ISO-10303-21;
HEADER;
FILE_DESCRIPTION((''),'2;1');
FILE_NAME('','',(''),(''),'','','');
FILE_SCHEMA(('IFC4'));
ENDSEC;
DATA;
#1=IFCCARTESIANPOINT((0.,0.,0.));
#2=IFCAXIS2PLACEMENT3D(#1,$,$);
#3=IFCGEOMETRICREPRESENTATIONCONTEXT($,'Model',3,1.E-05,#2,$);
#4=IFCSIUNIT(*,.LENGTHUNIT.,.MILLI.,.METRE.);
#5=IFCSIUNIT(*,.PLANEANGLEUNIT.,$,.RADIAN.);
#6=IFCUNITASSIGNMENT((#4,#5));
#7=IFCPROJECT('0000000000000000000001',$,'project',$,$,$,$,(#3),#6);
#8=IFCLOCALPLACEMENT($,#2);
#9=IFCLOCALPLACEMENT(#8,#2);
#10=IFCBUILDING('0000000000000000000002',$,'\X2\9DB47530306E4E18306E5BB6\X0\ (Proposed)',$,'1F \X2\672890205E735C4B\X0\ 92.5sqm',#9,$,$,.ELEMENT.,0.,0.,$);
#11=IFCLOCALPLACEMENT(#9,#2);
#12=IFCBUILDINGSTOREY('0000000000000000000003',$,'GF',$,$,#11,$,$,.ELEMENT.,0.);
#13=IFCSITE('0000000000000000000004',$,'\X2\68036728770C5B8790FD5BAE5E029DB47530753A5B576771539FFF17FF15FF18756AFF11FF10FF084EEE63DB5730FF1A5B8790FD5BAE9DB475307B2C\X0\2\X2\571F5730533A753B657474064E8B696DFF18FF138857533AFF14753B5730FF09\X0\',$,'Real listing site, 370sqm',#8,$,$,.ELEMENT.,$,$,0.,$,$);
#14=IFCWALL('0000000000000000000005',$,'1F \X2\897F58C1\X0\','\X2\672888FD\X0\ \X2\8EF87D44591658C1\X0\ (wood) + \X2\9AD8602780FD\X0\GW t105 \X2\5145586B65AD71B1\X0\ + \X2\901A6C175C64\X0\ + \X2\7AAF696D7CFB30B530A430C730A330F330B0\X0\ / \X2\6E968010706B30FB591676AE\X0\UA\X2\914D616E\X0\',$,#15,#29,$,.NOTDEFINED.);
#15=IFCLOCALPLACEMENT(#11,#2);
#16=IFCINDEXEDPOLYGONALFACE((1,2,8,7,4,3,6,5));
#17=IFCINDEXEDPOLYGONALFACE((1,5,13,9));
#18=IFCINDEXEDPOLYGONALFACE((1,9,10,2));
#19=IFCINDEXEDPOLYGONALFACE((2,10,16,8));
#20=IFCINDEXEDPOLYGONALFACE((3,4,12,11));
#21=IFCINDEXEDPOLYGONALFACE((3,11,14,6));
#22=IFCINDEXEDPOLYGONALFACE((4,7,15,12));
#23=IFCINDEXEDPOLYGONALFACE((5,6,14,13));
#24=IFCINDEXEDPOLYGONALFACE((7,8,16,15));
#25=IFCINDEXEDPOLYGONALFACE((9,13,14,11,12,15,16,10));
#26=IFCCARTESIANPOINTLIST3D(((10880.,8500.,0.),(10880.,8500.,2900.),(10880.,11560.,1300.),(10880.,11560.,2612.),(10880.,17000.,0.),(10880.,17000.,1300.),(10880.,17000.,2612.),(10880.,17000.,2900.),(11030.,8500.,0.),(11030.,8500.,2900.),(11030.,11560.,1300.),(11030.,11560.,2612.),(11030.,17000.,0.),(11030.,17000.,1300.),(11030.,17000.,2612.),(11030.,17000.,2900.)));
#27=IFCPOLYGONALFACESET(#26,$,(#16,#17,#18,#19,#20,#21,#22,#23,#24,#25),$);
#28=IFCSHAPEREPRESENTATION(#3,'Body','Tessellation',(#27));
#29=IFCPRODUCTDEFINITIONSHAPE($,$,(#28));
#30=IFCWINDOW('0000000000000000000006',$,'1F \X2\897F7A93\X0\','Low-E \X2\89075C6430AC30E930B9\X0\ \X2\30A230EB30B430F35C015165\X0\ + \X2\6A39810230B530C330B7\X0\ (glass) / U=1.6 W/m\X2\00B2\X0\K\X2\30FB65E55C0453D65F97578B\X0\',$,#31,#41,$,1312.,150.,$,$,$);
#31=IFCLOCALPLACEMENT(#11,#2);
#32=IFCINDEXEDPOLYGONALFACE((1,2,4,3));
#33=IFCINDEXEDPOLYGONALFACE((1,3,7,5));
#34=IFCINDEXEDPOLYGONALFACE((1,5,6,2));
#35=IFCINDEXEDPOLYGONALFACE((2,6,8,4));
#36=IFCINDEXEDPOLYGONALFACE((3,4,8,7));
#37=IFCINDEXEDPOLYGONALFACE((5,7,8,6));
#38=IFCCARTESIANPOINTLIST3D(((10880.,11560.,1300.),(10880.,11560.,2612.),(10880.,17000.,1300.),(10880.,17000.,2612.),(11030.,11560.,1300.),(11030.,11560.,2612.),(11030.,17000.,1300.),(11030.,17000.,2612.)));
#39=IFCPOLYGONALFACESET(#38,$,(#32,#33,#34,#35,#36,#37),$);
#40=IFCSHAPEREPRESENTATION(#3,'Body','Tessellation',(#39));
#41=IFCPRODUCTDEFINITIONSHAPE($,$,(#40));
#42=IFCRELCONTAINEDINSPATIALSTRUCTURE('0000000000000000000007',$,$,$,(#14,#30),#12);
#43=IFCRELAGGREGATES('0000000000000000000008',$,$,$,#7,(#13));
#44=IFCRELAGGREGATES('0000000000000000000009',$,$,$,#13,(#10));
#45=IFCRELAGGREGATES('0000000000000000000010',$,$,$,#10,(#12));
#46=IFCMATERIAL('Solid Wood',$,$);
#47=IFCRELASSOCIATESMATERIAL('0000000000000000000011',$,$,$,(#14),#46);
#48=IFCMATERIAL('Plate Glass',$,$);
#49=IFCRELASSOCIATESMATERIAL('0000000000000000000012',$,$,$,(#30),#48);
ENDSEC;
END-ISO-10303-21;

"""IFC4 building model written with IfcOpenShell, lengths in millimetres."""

from ifc_helpers import new_model, si_unit, frame, frame_2d, origin, place, context, project, spatial, rectangle, extrude, material, element, fill, save


model = new_model("IFC4")

# Units and contexts
model_context = context("Model", 3, precision=1e-05, world=origin())
ifc_project = project(units=[si_unit("LENGTHUNIT", "METRE", prefix="MILLI"), si_unit("PLANEANGLEUNIT", "RADIAN")], contexts=[model_context])

# Site, building, storey
site_placement = place(None, origin())
site = spatial("IfcSite", under=ifc_project, at=site_placement, Name="栃木県宇都宮市鶴田町字東原７５８番１０（仮換地：宇都宮鶴田第2土地区画整理事業８３街区４画地）", ObjectType="Real listing site, 370sqm", CompositionType="ELEMENT", RefElevation=0.0)
building_placement = place(site_placement, origin())
building = spatial("IfcBuilding", under=site, at=building_placement, Name="鶴田の丘の家 (Proposed)", ObjectType="1F 木造平屋 92.5sqm", CompositionType="ELEMENT", ElevationOfRefHeight=0.0, ElevationOfTerrain=0.0)
storey_placement = place(building_placement, origin())
storey = spatial("IfcBuildingStorey", under=building, at=storey_placement, Name="GF", CompositionType="ELEMENT", Elevation=0.0)

# Shared definitions
ifc_material_1 = material(Name="Solid Wood")

# Shared definitions
ifc_material_2 = material(Name="Plate Glass")

# Wall, opening, window
wall_1_placement = place(storey_placement, frame((5440.0, 4250.0, 0.0)))
wall_1 = element("IfcWall", 1, at=wall_1_placement, inside=storey, material=ifc_material_1, Name="1F 西壁", Description="木製 軸組外壁 (wood) + 高性能GW t105 充填断熱 + 通気層 + 窯業系サイディング / 準耐火・外皮UA配慮", PredefinedType="NOTDEFINED", context=model_context, shape_type="SweptSolid", body=[
    extrude(rectangle(XDim=150.0, YDim=8500.0, at=frame_2d((75.0, 4250.0))), frame((5440.0, 4250.0, 0.0)), (0.0, 0.0, 1.0), 2900.0),
])
opening_1_placement = place(storey_placement, frame((5440.0, 5780.0, 650.0)))
opening_1 = element("IfcOpeningElement", 2, at=opening_1_placement, cuts=wall_1, PredefinedType="NOTDEFINED", context=model_context, shape_type="SweptSolid", body=[
    extrude(rectangle(XDim=150.0, YDim=5440.0, at=frame_2d((75.0, 2720.0))), frame((5440.0, 5780.0, 650.0)), (0.0, 0.0, 1.0), 1312.0),
])
window_1_placement = place(storey_placement, frame((5440.0, 5780.0, 650.0)))
window_1 = element("IfcWindow", 3, at=window_1_placement, inside=storey, material=ifc_material_2, Name="1F 西窓", Description="Low-E 複層ガラス アルゴン封入 + 樹脂サッシ (glass) / U=1.6 W/m²K・日射取得型", OverallHeight=1312.0, OverallWidth=150.0, context=model_context, shape_type="SweptSolid", body=[
    extrude(rectangle(XDim=150.0, YDim=5440.0, at=frame_2d((75.0, 2720.0))), frame((5440.0, 5780.0, 650.0)), (0.0, 0.0, 1.0), 1312.0),
])
fill(opening_1, window_1)

save(model, "model.ifc")
